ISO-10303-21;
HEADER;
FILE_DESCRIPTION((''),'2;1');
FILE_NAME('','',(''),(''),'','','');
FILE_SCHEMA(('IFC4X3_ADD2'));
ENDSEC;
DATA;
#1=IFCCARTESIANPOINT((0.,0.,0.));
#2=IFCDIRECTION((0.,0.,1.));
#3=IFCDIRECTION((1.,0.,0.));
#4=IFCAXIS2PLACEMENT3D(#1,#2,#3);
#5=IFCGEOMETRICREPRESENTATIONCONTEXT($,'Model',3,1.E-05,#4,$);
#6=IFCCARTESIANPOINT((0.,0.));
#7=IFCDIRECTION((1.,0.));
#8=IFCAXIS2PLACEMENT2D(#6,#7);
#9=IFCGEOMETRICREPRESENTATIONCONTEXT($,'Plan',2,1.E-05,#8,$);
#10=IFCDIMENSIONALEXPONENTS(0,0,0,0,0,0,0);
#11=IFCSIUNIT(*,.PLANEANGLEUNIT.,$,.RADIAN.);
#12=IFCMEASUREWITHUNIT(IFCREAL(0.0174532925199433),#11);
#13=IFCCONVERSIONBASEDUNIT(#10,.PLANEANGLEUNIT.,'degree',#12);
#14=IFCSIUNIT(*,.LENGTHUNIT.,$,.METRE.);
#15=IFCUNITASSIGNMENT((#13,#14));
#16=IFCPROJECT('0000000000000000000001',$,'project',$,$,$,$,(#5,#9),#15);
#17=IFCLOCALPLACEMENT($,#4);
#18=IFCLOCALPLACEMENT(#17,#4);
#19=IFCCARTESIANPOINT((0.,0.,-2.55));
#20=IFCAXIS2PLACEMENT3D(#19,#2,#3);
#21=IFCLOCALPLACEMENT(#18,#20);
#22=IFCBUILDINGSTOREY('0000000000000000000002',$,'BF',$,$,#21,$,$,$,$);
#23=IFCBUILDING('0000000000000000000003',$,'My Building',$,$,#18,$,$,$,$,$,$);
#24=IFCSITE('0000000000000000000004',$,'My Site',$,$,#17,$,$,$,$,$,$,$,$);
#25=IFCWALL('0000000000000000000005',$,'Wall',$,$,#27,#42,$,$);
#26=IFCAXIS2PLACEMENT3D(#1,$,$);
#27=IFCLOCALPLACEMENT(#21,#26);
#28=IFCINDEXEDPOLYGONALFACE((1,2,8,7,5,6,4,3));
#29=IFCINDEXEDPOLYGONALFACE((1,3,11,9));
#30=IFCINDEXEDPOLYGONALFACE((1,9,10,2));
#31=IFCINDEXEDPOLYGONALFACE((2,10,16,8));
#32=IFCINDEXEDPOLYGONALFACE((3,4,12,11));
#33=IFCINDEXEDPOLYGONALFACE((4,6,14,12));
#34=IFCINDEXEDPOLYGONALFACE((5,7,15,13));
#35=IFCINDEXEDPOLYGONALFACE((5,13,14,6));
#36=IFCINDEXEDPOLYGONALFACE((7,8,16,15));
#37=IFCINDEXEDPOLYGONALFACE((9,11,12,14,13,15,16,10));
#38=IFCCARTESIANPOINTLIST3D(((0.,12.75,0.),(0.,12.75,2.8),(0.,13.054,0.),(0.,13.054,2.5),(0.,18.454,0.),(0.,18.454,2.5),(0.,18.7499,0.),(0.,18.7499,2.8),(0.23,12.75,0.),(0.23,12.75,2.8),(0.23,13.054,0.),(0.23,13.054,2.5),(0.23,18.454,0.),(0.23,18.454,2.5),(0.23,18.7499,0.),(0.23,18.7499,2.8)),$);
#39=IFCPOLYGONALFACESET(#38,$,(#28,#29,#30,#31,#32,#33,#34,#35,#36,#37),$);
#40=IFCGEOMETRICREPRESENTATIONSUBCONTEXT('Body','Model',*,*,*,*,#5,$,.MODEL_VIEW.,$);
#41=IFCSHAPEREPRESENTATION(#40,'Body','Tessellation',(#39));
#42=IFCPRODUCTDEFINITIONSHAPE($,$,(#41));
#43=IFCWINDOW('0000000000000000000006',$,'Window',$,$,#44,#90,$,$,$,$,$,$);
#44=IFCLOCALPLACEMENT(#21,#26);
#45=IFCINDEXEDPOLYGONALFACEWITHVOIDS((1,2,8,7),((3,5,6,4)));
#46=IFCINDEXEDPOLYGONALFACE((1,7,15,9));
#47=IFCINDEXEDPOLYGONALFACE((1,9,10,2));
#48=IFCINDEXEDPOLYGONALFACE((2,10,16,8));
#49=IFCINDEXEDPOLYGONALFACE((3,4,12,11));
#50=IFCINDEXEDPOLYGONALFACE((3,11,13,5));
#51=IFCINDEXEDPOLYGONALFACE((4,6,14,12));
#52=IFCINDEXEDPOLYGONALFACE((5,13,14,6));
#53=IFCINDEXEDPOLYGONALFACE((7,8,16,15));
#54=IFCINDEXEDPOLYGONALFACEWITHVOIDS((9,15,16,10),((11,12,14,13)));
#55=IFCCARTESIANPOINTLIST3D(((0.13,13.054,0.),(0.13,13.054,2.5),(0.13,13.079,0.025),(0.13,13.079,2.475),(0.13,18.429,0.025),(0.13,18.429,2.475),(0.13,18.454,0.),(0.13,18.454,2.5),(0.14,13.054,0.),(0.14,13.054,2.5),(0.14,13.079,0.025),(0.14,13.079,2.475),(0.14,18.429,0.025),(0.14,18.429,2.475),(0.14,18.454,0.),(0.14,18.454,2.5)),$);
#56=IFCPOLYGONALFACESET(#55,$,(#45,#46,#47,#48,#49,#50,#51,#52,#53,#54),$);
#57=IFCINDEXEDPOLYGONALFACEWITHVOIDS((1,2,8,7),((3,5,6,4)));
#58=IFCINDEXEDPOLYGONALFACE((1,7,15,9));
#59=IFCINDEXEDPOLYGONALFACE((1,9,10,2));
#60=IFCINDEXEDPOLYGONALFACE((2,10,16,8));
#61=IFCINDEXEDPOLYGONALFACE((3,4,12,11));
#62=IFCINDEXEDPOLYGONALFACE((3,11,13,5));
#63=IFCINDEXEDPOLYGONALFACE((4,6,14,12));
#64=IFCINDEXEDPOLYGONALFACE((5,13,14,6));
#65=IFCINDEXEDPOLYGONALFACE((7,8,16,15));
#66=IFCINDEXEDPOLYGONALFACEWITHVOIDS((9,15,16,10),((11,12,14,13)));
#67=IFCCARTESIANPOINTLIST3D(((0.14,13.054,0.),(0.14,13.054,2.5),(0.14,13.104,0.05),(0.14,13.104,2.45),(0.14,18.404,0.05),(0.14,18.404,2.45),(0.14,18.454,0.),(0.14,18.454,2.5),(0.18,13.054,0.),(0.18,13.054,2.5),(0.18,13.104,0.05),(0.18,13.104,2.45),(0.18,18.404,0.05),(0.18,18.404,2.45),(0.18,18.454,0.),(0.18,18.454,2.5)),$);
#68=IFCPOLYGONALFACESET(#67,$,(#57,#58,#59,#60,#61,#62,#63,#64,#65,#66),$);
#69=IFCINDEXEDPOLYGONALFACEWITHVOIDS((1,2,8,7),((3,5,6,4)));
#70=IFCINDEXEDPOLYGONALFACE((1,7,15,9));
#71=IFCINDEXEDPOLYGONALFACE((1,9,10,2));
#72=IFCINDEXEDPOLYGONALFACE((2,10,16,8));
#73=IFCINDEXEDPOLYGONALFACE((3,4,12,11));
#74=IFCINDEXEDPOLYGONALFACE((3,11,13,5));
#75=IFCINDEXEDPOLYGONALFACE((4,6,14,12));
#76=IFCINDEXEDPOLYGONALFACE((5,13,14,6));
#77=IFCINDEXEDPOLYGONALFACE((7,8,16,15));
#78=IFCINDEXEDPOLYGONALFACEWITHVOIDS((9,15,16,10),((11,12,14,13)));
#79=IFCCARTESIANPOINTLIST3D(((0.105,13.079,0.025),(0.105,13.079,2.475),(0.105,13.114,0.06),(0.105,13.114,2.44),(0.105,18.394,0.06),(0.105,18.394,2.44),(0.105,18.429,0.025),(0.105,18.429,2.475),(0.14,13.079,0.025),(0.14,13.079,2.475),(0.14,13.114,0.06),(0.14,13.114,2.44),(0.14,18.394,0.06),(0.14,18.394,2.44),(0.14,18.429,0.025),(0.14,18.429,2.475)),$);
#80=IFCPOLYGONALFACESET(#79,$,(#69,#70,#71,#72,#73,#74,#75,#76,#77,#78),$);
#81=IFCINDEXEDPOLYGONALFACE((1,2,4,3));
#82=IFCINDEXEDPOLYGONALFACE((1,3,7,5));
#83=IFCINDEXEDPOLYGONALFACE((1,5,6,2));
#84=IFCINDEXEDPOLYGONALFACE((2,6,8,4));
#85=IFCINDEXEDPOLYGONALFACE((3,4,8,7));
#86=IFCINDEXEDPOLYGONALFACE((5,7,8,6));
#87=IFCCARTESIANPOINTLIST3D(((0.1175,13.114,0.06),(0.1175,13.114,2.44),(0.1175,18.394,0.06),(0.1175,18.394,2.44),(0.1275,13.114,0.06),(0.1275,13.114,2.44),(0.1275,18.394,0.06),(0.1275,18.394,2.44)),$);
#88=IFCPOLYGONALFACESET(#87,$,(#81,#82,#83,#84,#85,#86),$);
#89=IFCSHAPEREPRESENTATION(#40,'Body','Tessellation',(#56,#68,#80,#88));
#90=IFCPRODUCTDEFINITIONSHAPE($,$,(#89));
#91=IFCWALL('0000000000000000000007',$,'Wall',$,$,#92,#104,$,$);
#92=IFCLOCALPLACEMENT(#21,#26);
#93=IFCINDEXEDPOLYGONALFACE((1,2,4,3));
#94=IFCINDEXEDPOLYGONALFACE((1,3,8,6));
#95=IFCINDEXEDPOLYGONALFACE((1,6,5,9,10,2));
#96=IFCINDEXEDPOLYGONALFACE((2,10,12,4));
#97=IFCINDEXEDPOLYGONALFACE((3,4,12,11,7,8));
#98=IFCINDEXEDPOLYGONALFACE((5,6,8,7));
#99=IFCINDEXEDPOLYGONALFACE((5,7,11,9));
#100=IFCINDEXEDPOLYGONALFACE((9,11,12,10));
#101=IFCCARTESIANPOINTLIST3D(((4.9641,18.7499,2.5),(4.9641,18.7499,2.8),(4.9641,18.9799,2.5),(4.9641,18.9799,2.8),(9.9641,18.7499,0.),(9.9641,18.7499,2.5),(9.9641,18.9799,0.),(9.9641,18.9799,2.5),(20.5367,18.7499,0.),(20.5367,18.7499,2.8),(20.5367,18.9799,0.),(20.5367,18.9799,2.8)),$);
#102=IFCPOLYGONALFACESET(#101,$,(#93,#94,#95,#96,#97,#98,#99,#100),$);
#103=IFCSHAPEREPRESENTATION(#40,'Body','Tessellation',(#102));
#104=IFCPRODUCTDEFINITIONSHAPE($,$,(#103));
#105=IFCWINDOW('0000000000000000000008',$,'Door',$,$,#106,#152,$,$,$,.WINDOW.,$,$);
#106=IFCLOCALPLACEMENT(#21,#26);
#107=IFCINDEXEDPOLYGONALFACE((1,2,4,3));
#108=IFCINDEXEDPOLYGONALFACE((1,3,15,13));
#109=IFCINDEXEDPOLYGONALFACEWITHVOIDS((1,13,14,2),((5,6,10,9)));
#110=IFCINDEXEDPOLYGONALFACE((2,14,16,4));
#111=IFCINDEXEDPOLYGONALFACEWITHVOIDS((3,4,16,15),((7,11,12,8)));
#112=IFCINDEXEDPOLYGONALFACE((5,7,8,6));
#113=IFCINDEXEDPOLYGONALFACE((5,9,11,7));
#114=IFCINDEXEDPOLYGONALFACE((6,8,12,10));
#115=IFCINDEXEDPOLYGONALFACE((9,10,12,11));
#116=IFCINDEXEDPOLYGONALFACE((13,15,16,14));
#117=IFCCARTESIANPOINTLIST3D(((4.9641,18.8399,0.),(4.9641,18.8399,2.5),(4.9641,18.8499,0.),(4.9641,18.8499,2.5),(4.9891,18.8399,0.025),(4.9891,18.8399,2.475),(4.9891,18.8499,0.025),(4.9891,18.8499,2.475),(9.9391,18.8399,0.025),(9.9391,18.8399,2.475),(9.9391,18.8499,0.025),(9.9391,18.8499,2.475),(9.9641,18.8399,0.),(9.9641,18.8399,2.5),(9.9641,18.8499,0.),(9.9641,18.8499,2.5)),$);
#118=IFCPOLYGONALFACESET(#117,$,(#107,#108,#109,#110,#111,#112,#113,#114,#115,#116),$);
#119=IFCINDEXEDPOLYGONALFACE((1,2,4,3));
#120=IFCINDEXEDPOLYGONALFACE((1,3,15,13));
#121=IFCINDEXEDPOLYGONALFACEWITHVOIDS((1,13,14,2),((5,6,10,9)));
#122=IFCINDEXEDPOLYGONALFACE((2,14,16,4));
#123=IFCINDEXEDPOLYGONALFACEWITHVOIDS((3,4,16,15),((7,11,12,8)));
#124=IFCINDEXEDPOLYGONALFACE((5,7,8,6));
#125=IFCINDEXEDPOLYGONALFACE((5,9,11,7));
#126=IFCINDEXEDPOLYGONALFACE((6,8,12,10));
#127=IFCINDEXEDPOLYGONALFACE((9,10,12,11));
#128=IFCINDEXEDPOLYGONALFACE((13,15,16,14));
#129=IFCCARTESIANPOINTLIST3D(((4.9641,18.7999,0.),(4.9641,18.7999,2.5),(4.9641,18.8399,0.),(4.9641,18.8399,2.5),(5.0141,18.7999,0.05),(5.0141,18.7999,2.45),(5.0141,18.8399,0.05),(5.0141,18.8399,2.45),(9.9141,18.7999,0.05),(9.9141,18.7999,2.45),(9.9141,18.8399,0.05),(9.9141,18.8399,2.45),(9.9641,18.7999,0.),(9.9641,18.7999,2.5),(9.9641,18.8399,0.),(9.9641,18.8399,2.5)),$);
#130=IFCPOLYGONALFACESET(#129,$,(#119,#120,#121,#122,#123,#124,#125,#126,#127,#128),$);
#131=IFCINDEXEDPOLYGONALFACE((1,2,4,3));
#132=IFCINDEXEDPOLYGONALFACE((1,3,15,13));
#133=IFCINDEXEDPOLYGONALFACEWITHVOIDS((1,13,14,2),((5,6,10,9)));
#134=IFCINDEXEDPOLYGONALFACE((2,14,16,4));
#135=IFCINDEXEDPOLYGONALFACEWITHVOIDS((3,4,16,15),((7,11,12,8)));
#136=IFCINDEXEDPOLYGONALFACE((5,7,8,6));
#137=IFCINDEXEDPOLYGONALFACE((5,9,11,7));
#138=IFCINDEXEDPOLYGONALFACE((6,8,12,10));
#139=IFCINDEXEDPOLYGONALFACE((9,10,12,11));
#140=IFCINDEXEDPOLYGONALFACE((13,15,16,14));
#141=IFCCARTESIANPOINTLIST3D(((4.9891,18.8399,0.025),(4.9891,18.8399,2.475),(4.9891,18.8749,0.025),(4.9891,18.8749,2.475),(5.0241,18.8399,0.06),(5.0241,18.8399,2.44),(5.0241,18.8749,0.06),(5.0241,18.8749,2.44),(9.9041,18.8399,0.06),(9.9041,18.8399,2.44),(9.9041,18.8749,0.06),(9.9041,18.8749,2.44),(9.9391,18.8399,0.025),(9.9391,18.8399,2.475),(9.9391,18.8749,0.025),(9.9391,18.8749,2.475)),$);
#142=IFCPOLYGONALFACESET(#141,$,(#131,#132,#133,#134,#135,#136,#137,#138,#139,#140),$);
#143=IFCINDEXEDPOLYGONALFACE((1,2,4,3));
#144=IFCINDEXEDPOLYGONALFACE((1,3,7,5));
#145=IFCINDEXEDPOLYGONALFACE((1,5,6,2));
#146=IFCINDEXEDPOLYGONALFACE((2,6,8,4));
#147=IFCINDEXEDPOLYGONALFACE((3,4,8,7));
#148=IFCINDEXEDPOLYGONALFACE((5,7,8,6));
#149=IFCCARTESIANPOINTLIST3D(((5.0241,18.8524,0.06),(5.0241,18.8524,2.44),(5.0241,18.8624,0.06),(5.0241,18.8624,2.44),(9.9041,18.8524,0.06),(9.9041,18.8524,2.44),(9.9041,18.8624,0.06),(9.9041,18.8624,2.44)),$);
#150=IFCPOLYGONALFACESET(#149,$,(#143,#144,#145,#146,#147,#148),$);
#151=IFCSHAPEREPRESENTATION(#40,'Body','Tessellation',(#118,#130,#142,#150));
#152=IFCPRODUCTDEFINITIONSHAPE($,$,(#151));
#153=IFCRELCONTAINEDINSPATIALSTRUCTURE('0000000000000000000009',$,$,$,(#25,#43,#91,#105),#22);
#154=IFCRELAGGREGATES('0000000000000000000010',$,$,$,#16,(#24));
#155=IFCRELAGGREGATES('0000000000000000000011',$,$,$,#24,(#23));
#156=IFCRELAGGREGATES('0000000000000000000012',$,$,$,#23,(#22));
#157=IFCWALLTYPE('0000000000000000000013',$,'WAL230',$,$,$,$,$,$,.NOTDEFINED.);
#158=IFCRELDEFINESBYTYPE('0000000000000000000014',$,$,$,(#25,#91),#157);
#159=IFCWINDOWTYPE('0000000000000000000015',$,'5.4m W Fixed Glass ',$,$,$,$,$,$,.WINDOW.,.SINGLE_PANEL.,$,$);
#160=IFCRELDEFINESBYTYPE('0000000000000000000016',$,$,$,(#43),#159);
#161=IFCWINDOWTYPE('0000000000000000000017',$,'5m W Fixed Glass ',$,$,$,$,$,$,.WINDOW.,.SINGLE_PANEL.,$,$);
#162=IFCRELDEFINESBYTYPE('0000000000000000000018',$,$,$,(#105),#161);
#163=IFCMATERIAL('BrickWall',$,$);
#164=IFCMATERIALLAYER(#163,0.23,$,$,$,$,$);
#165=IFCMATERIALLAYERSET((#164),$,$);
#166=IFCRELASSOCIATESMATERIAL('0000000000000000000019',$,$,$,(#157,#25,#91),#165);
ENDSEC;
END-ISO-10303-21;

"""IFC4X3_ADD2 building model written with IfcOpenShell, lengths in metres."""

from ifc_helpers import new_model, entity, si_unit, converted_unit, frame, origin_with_axes, origin_2d_with_axis, place, context, subcontext, project, spatial, line, indexed_curve, outline, extrude, shape, source, transform, mapped, material, layer, layer_set, layer_usage, type_object, type_shapes, element, fill, save


model = new_model("IFC4X3_ADD2")

# Units and contexts
model_context = context("Model", 3, precision=1e-05, world=origin_with_axes())
plan_context = context("Plan", 2, precision=1e-05, world=origin_2d_with_axis())
body_context_1 = subcontext(model_context, "Body", "Model", "MODEL_VIEW")
body_context_2 = subcontext(plan_context, "Body", "Plan", "PLAN_VIEW")
ifc_project = project(units=[converted_unit("PLANEANGLEUNIT", "degree", entity("IfcReal", 0.0174532925199433), si_unit("PLANEANGLEUNIT", "RADIAN"), dimensions=[0, 0, 0, 0, 0, 0, 0]), si_unit("LENGTHUNIT", "METRE")], contexts=[model_context, plan_context])

# Site, building, storey
site_placement = place(None, origin_with_axes())
site = spatial("IfcSite", under=ifc_project, at=site_placement, Name="My Site")
building_placement = place(site_placement, origin_with_axes())
building = spatial("IfcBuilding", under=site, at=building_placement, Name="My Building")
storey_placement = place(building_placement, frame((0.0, 0.0, -2.55), z_axis=(0.0, 0.0, 1.0), x_axis=(1.0, 0.0, 0.0)))
storey = spatial("IfcBuildingStorey", under=building, at=storey_placement, Name="BF")

# Shared definitions
ifc_material_1 = material(Name="BrickWall")

# Shared definitions
ifc_layer_1 = layer(ifc_material_1, 0.23)
ifc_layer_set_1 = layer_set([ifc_layer_1])
wall_type = type_object("IfcWallType", Name="WAL230", PredefinedType="NOTDEFINED", material=ifc_layer_set_1)
shared_shape_1 = source(origin_with_axes(), body_context_1, "Body", "SweptSolid", [
    extrude(outline(indexed_curve([(0.0, 0.0), (5.4, 0.0), (5.4, 2.5), (0.0, 2.5)], segments=[line(1, 2, 3, 4, 1)])), frame((0.0, -0.6, 0.0), z_axis=(0.0, -1.0, 0.0), x_axis=(1.0, 0.0, 0.0)), (0.0, 0.0, -1.0), 1.2),
])
window_type_1 = type_object("IfcWindowType", Name="5.4m W Fixed Glass ", PartitioningType="SINGLE_PANEL", PredefinedType="WINDOW")
shared_shape_2 = source(origin_with_axes(), body_context_1, "Body", "SweptSolid", [
    extrude(outline(indexed_curve([(0.0, 0.0), (5.4, 0.0), (5.4, 2.5), (0.0, 2.5)], segments=[line(1, 2, 3, 4, 1)]), holes=[indexed_curve([(0.025, 0.025), (5.375, 0.025), (5.375, 2.475), (0.025, 2.475)], segments=[line(1, 2, 3, 4, 1)])]), frame((0.0, 0.09, 0.0), z_axis=(0.0, -1.0, 0.0), x_axis=(1.0, 0.0, 0.0)), (0.0, 0.0, -1.0), 0.01),
    extrude(outline(indexed_curve([(0.0, 0.0), (5.4, 0.0), (5.4, 2.5), (0.0, 2.5)], segments=[line(1, 2, 3, 4, 1)]), holes=[indexed_curve([(0.05, 0.05), (5.35, 0.05), (5.35, 2.45), (0.05, 2.45)], segments=[line(1, 2, 3, 4, 1)])]), frame((0.0, 0.05, 0.0), z_axis=(0.0, -1.0, 0.0), x_axis=(1.0, 0.0, 0.0)), (0.0, 0.0, -1.0), 0.04),
    extrude(outline(indexed_curve([(0.0, 0.0), (5.35, 0.0), (5.35, 2.45), (0.0, 2.45)], segments=[line(1, 2, 3, 4, 1)]), holes=[indexed_curve([(0.035, 0.035), (5.315, 0.035), (5.315, 2.415), (0.035, 2.415)], segments=[line(1, 2, 3, 4, 1)])]), frame((0.025, 0.09, 0.025), z_axis=(0.0, -1.0, 0.0), x_axis=(1.0, 0.0, 0.0)), (0.0, 0.0, -1.0), 0.035),
    extrude(outline(indexed_curve([(0.035, 0.035), (5.315, 0.035), (5.315, 2.415), (0.035, 2.415)], segments=[line(1, 2, 3, 4, 1)])), frame((0.025, 0.1025, 0.025), z_axis=(0.0, -1.0, 0.0), x_axis=(1.0, 0.0, 0.0)), (0.0, 0.0, -1.0), 0.01),
])
shared_shape_3 = source(origin_with_axes(), body_context_2, "Body", "Curve2D", [
    entity("IfcIndexedPolyCurve", entity("IfcCartesianPointList2D", [[0.05, 0.05], [5.35, 0.05]])),
    entity("IfcIndexedPolyCurve", entity("IfcCartesianPointList2D", [[0.0, 0.1], [0.025, 0.1], [0.025, 0.09], [0.05, 0.09], [0.05, 0.05], [0.0, 0.05]]), [entity("IfcLineIndex", [1, 2, 3, 4, 5, 6, 1])]),
    entity("IfcIndexedPolyCurve", entity("IfcCartesianPointList2D", [[5.4, 0.1], [5.375, 0.1], [5.375, 0.09], [5.35, 0.09], [5.35, 0.05], [5.4, 0.05]]), [entity("IfcLineIndex", [1, 2, 3, 4, 5, 6, 1])]),
    entity("IfcIndexedPolyCurve", entity("IfcCartesianPointList2D", [[0.025, 0.09], [0.06, 0.09], [0.06, 0.125], [0.025, 0.125]]), [entity("IfcLineIndex", [1, 2, 3, 4, 1])]),
    entity("IfcIndexedPolyCurve", entity("IfcCartesianPointList2D", [[5.375, 0.09], [5.34, 0.09], [5.34, 0.125], [5.375, 0.125]]), [entity("IfcLineIndex", [1, 2, 3, 4, 1])]),
    entity("IfcIndexedPolyCurve", entity("IfcCartesianPointList2D", [[0.06, 0.09], [5.34, 0.09]])),
    entity("IfcIndexedPolyCurve", entity("IfcCartesianPointList2D", [[0.06, 0.125], [5.34, 0.125]])),
    entity("IfcIndexedPolyCurve", entity("IfcCartesianPointList2D", [[0.06, 0.1075], [5.34, 0.1075]])),
])
type_shapes(window_type_1, [shared_shape_2, shared_shape_3])

# Walls, openings, windows
ifc_layer_usage_1 = layer_usage(ifc_layer_set_1, "AXIS2", "POSITIVE", 0.0)
wall_1_placement = place(storey_placement, frame((0.23, 12.75, 0.0), z_axis=(0.0, 0.0, 1.0), x_axis=(0.0, 1.0, 0.0)))
wall_1 = element("IfcWall", 1, at=wall_1_placement, inside=storey, type_object=wall_type, material=ifc_layer_usage_1, Name="Wall", context=body_context_1, shape_type="SweptSolid", body=[
    extrude(outline(indexed_curve([(0.0, 0.0), (0.0, 0.23), (5.9999, 0.23), (5.9999, 0.0), (0.0, 0.0)], self_intersect=False)), origin_with_axes(), (0.0, 0.0, 1.0), 2.8),
])
opening_1_placement = place(wall_1_placement, frame((0.304, 0.0, 0.0), z_axis=(0.0, 0.0, 1.0), x_axis=(1.0, 0.0, 0.0)))
opening_1 = element("IfcOpeningElement", 2, at=opening_1_placement, cuts=wall_1, PredefinedType="OPENING", context=body_context_1, shape_type="MappedRepresentation", body=[
    mapped(shared_shape_1, transform((0.0, 0.0, 0.0), x_axis=(1.0, 0.0, 0.0), y_axis=(0.0, 1.0, 0.0), z_axis=(0.0, 0.0, 1.0), scale=1.0)),
])
window_1_placement = place(opening_1_placement, frame((0.0, 0.0, 0.0), z_axis=(0.0, 0.0, 1.0), x_axis=(1.0, 0.0, 0.0)))
window_1 = element("IfcWindow", 3, at=window_1_placement, inside=storey, type_object=window_type_1, Name="Window", shapes=[
    shape(body_context_1, "Body", "MappedRepresentation", [mapped(shared_shape_2, transform((0.0, 0.0, 0.0), x_axis=(1.0, 0.0, 0.0), y_axis=(0.0, 1.0, 0.0), z_axis=(0.0, 0.0, 1.0), scale=1.0))]),
    shape(body_context_2, "Body", "MappedRepresentation", [mapped(shared_shape_3, transform((0.0, 0.0, 0.0), x_axis=(1.0, 0.0, 0.0), y_axis=(0.0, 1.0, 0.0), z_axis=(0.0, 0.0, 1.0), scale=1.0))]),
])
fill(opening_1, window_1)
ifc_layer_usage_2 = layer_usage(ifc_layer_set_1, "AXIS2", "POSITIVE", 0.0)
wall_2_placement = place(storey_placement, frame((4.9641, 18.7499, 0.0), z_axis=(0.0, 0.0, 1.0), x_axis=(1.0, 0.0, 0.0)))
wall_2 = element("IfcWall", 4, at=wall_2_placement, inside=storey, type_object=wall_type, material=ifc_layer_usage_2, Name="Wall", context=body_context_1, shape_type="SweptSolid", body=[
    extrude(outline(indexed_curve([(0.0, 0.0), (0.0, 0.23), (15.5727, 0.23), (15.5727, 0.0), (0.0, 0.0)], self_intersect=False)), origin_with_axes(), (0.0, 0.0, 1.0), 2.8),
])
shared_shape_4 = source(origin_with_axes(), body_context_1, "Body", "SweptSolid", [
    extrude(outline(indexed_curve([(0.0, 0.0), (5.0, 0.0), (5.0, 2.5), (0.0, 2.5)], segments=[line(1, 2, 3, 4, 1)])), frame((0.0, -0.6, 0.0), z_axis=(0.0, -1.0, 0.0), x_axis=(1.0, 0.0, 0.0)), (0.0, 0.0, -1.0), 1.2),
])
opening_2_placement = place(wall_2_placement, frame((0.0, 0.0, 0.0), z_axis=(0.0, 0.0, 1.0), x_axis=(1.0, 0.0, 0.0)))
opening_2 = element("IfcOpeningElement", 5, at=opening_2_placement, cuts=wall_2, PredefinedType="OPENING", context=body_context_1, shape_type="MappedRepresentation", body=[
    mapped(shared_shape_4, transform((0.0, 0.0, 0.0), x_axis=(1.0, 0.0, 0.0), y_axis=(0.0, 1.0, 0.0), z_axis=(0.0, 0.0, 1.0), scale=1.0)),
])
window_type_2 = type_object("IfcWindowType", Name="5m W Fixed Glass ", PartitioningType="SINGLE_PANEL", PredefinedType="WINDOW")
shared_shape_5 = source(origin_with_axes(), body_context_1, "Body", "SweptSolid", [
    extrude(outline(indexed_curve([(0.0, 0.0), (5.0, 0.0), (5.0, 2.5), (0.0, 2.5)], segments=[line(1, 2, 3, 4, 1)]), holes=[indexed_curve([(0.025, 0.025), (4.975, 0.025), (4.975, 2.475), (0.025, 2.475)], segments=[line(1, 2, 3, 4, 1)])]), frame((0.0, 0.09, 0.0), z_axis=(0.0, -1.0, 0.0), x_axis=(1.0, 0.0, 0.0)), (0.0, 0.0, -1.0), 0.01),
    extrude(outline(indexed_curve([(0.0, 0.0), (5.0, 0.0), (5.0, 2.5), (0.0, 2.5)], segments=[line(1, 2, 3, 4, 1)]), holes=[indexed_curve([(0.05, 0.05), (4.95, 0.05), (4.95, 2.45), (0.05, 2.45)], segments=[line(1, 2, 3, 4, 1)])]), frame((0.0, 0.05, 0.0), z_axis=(0.0, -1.0, 0.0), x_axis=(1.0, 0.0, 0.0)), (0.0, 0.0, -1.0), 0.04),
    extrude(outline(indexed_curve([(0.0, 0.0), (4.95, 0.0), (4.95, 2.45), (0.0, 2.45)], segments=[line(1, 2, 3, 4, 1)]), holes=[indexed_curve([(0.035, 0.035), (4.915, 0.035), (4.915, 2.415), (0.035, 2.415)], segments=[line(1, 2, 3, 4, 1)])]), frame((0.025, 0.09, 0.025), z_axis=(0.0, -1.0, 0.0), x_axis=(1.0, 0.0, 0.0)), (0.0, 0.0, -1.0), 0.035),
    extrude(outline(indexed_curve([(0.035, 0.035), (4.915, 0.035), (4.915, 2.415), (0.035, 2.415)], segments=[line(1, 2, 3, 4, 1)])), frame((0.025, 0.1025, 0.025), z_axis=(0.0, -1.0, 0.0), x_axis=(1.0, 0.0, 0.0)), (0.0, 0.0, -1.0), 0.01),
])
shared_shape_6 = source(origin_with_axes(), body_context_2, "Body", "Curve2D", [
    entity("IfcIndexedPolyCurve", entity("IfcCartesianPointList2D", [[0.05, 0.05], [4.95, 0.05]])),
    entity("IfcIndexedPolyCurve", entity("IfcCartesianPointList2D", [[0.0, 0.1], [0.025, 0.1], [0.025, 0.09], [0.05, 0.09], [0.05, 0.05], [0.0, 0.05]]), [entity("IfcLineIndex", [1, 2, 3, 4, 5, 6, 1])]),
    entity("IfcIndexedPolyCurve", entity("IfcCartesianPointList2D", [[5.0, 0.1], [4.975, 0.1], [4.975, 0.09], [4.95, 0.09], [4.95, 0.05], [5.0, 0.05]]), [entity("IfcLineIndex", [1, 2, 3, 4, 5, 6, 1])]),
    entity("IfcIndexedPolyCurve", entity("IfcCartesianPointList2D", [[0.025, 0.09], [0.06, 0.09], [0.06, 0.125], [0.025, 0.125]]), [entity("IfcLineIndex", [1, 2, 3, 4, 1])]),
    entity("IfcIndexedPolyCurve", entity("IfcCartesianPointList2D", [[4.975, 0.09], [4.94, 0.09], [4.94, 0.125], [4.975, 0.125]]), [entity("IfcLineIndex", [1, 2, 3, 4, 1])]),
    entity("IfcIndexedPolyCurve", entity("IfcCartesianPointList2D", [[0.06, 0.09], [4.94, 0.09]])),
    entity("IfcIndexedPolyCurve", entity("IfcCartesianPointList2D", [[0.06, 0.125], [4.94, 0.125]])),
    entity("IfcIndexedPolyCurve", entity("IfcCartesianPointList2D", [[0.06, 0.1075], [4.94, 0.1075]])),
])
type_shapes(window_type_2, [shared_shape_5, shared_shape_6])
window_2_placement = place(opening_2_placement, origin_with_axes())
window_2 = element("IfcWindow", 6, at=window_2_placement, inside=storey, type_object=window_type_2, Name="Door", PredefinedType="WINDOW", shapes=[
    shape(body_context_1, "Body", "MappedRepresentation", [mapped(shared_shape_5, transform((0.0, 0.0, 0.0), x_axis=(1.0, 0.0, 0.0), y_axis=(0.0, 1.0, 0.0), z_axis=(0.0, 0.0, 1.0), scale=1.0))]),
    shape(body_context_2, "Body", "MappedRepresentation", [mapped(shared_shape_6, transform((0.0, 0.0, 0.0), x_axis=(1.0, 0.0, 0.0), y_axis=(0.0, 1.0, 0.0), z_axis=(0.0, 0.0, 1.0), scale=1.0))]),
])
fill(opening_2, window_2)

save(model, "model.ifc")
